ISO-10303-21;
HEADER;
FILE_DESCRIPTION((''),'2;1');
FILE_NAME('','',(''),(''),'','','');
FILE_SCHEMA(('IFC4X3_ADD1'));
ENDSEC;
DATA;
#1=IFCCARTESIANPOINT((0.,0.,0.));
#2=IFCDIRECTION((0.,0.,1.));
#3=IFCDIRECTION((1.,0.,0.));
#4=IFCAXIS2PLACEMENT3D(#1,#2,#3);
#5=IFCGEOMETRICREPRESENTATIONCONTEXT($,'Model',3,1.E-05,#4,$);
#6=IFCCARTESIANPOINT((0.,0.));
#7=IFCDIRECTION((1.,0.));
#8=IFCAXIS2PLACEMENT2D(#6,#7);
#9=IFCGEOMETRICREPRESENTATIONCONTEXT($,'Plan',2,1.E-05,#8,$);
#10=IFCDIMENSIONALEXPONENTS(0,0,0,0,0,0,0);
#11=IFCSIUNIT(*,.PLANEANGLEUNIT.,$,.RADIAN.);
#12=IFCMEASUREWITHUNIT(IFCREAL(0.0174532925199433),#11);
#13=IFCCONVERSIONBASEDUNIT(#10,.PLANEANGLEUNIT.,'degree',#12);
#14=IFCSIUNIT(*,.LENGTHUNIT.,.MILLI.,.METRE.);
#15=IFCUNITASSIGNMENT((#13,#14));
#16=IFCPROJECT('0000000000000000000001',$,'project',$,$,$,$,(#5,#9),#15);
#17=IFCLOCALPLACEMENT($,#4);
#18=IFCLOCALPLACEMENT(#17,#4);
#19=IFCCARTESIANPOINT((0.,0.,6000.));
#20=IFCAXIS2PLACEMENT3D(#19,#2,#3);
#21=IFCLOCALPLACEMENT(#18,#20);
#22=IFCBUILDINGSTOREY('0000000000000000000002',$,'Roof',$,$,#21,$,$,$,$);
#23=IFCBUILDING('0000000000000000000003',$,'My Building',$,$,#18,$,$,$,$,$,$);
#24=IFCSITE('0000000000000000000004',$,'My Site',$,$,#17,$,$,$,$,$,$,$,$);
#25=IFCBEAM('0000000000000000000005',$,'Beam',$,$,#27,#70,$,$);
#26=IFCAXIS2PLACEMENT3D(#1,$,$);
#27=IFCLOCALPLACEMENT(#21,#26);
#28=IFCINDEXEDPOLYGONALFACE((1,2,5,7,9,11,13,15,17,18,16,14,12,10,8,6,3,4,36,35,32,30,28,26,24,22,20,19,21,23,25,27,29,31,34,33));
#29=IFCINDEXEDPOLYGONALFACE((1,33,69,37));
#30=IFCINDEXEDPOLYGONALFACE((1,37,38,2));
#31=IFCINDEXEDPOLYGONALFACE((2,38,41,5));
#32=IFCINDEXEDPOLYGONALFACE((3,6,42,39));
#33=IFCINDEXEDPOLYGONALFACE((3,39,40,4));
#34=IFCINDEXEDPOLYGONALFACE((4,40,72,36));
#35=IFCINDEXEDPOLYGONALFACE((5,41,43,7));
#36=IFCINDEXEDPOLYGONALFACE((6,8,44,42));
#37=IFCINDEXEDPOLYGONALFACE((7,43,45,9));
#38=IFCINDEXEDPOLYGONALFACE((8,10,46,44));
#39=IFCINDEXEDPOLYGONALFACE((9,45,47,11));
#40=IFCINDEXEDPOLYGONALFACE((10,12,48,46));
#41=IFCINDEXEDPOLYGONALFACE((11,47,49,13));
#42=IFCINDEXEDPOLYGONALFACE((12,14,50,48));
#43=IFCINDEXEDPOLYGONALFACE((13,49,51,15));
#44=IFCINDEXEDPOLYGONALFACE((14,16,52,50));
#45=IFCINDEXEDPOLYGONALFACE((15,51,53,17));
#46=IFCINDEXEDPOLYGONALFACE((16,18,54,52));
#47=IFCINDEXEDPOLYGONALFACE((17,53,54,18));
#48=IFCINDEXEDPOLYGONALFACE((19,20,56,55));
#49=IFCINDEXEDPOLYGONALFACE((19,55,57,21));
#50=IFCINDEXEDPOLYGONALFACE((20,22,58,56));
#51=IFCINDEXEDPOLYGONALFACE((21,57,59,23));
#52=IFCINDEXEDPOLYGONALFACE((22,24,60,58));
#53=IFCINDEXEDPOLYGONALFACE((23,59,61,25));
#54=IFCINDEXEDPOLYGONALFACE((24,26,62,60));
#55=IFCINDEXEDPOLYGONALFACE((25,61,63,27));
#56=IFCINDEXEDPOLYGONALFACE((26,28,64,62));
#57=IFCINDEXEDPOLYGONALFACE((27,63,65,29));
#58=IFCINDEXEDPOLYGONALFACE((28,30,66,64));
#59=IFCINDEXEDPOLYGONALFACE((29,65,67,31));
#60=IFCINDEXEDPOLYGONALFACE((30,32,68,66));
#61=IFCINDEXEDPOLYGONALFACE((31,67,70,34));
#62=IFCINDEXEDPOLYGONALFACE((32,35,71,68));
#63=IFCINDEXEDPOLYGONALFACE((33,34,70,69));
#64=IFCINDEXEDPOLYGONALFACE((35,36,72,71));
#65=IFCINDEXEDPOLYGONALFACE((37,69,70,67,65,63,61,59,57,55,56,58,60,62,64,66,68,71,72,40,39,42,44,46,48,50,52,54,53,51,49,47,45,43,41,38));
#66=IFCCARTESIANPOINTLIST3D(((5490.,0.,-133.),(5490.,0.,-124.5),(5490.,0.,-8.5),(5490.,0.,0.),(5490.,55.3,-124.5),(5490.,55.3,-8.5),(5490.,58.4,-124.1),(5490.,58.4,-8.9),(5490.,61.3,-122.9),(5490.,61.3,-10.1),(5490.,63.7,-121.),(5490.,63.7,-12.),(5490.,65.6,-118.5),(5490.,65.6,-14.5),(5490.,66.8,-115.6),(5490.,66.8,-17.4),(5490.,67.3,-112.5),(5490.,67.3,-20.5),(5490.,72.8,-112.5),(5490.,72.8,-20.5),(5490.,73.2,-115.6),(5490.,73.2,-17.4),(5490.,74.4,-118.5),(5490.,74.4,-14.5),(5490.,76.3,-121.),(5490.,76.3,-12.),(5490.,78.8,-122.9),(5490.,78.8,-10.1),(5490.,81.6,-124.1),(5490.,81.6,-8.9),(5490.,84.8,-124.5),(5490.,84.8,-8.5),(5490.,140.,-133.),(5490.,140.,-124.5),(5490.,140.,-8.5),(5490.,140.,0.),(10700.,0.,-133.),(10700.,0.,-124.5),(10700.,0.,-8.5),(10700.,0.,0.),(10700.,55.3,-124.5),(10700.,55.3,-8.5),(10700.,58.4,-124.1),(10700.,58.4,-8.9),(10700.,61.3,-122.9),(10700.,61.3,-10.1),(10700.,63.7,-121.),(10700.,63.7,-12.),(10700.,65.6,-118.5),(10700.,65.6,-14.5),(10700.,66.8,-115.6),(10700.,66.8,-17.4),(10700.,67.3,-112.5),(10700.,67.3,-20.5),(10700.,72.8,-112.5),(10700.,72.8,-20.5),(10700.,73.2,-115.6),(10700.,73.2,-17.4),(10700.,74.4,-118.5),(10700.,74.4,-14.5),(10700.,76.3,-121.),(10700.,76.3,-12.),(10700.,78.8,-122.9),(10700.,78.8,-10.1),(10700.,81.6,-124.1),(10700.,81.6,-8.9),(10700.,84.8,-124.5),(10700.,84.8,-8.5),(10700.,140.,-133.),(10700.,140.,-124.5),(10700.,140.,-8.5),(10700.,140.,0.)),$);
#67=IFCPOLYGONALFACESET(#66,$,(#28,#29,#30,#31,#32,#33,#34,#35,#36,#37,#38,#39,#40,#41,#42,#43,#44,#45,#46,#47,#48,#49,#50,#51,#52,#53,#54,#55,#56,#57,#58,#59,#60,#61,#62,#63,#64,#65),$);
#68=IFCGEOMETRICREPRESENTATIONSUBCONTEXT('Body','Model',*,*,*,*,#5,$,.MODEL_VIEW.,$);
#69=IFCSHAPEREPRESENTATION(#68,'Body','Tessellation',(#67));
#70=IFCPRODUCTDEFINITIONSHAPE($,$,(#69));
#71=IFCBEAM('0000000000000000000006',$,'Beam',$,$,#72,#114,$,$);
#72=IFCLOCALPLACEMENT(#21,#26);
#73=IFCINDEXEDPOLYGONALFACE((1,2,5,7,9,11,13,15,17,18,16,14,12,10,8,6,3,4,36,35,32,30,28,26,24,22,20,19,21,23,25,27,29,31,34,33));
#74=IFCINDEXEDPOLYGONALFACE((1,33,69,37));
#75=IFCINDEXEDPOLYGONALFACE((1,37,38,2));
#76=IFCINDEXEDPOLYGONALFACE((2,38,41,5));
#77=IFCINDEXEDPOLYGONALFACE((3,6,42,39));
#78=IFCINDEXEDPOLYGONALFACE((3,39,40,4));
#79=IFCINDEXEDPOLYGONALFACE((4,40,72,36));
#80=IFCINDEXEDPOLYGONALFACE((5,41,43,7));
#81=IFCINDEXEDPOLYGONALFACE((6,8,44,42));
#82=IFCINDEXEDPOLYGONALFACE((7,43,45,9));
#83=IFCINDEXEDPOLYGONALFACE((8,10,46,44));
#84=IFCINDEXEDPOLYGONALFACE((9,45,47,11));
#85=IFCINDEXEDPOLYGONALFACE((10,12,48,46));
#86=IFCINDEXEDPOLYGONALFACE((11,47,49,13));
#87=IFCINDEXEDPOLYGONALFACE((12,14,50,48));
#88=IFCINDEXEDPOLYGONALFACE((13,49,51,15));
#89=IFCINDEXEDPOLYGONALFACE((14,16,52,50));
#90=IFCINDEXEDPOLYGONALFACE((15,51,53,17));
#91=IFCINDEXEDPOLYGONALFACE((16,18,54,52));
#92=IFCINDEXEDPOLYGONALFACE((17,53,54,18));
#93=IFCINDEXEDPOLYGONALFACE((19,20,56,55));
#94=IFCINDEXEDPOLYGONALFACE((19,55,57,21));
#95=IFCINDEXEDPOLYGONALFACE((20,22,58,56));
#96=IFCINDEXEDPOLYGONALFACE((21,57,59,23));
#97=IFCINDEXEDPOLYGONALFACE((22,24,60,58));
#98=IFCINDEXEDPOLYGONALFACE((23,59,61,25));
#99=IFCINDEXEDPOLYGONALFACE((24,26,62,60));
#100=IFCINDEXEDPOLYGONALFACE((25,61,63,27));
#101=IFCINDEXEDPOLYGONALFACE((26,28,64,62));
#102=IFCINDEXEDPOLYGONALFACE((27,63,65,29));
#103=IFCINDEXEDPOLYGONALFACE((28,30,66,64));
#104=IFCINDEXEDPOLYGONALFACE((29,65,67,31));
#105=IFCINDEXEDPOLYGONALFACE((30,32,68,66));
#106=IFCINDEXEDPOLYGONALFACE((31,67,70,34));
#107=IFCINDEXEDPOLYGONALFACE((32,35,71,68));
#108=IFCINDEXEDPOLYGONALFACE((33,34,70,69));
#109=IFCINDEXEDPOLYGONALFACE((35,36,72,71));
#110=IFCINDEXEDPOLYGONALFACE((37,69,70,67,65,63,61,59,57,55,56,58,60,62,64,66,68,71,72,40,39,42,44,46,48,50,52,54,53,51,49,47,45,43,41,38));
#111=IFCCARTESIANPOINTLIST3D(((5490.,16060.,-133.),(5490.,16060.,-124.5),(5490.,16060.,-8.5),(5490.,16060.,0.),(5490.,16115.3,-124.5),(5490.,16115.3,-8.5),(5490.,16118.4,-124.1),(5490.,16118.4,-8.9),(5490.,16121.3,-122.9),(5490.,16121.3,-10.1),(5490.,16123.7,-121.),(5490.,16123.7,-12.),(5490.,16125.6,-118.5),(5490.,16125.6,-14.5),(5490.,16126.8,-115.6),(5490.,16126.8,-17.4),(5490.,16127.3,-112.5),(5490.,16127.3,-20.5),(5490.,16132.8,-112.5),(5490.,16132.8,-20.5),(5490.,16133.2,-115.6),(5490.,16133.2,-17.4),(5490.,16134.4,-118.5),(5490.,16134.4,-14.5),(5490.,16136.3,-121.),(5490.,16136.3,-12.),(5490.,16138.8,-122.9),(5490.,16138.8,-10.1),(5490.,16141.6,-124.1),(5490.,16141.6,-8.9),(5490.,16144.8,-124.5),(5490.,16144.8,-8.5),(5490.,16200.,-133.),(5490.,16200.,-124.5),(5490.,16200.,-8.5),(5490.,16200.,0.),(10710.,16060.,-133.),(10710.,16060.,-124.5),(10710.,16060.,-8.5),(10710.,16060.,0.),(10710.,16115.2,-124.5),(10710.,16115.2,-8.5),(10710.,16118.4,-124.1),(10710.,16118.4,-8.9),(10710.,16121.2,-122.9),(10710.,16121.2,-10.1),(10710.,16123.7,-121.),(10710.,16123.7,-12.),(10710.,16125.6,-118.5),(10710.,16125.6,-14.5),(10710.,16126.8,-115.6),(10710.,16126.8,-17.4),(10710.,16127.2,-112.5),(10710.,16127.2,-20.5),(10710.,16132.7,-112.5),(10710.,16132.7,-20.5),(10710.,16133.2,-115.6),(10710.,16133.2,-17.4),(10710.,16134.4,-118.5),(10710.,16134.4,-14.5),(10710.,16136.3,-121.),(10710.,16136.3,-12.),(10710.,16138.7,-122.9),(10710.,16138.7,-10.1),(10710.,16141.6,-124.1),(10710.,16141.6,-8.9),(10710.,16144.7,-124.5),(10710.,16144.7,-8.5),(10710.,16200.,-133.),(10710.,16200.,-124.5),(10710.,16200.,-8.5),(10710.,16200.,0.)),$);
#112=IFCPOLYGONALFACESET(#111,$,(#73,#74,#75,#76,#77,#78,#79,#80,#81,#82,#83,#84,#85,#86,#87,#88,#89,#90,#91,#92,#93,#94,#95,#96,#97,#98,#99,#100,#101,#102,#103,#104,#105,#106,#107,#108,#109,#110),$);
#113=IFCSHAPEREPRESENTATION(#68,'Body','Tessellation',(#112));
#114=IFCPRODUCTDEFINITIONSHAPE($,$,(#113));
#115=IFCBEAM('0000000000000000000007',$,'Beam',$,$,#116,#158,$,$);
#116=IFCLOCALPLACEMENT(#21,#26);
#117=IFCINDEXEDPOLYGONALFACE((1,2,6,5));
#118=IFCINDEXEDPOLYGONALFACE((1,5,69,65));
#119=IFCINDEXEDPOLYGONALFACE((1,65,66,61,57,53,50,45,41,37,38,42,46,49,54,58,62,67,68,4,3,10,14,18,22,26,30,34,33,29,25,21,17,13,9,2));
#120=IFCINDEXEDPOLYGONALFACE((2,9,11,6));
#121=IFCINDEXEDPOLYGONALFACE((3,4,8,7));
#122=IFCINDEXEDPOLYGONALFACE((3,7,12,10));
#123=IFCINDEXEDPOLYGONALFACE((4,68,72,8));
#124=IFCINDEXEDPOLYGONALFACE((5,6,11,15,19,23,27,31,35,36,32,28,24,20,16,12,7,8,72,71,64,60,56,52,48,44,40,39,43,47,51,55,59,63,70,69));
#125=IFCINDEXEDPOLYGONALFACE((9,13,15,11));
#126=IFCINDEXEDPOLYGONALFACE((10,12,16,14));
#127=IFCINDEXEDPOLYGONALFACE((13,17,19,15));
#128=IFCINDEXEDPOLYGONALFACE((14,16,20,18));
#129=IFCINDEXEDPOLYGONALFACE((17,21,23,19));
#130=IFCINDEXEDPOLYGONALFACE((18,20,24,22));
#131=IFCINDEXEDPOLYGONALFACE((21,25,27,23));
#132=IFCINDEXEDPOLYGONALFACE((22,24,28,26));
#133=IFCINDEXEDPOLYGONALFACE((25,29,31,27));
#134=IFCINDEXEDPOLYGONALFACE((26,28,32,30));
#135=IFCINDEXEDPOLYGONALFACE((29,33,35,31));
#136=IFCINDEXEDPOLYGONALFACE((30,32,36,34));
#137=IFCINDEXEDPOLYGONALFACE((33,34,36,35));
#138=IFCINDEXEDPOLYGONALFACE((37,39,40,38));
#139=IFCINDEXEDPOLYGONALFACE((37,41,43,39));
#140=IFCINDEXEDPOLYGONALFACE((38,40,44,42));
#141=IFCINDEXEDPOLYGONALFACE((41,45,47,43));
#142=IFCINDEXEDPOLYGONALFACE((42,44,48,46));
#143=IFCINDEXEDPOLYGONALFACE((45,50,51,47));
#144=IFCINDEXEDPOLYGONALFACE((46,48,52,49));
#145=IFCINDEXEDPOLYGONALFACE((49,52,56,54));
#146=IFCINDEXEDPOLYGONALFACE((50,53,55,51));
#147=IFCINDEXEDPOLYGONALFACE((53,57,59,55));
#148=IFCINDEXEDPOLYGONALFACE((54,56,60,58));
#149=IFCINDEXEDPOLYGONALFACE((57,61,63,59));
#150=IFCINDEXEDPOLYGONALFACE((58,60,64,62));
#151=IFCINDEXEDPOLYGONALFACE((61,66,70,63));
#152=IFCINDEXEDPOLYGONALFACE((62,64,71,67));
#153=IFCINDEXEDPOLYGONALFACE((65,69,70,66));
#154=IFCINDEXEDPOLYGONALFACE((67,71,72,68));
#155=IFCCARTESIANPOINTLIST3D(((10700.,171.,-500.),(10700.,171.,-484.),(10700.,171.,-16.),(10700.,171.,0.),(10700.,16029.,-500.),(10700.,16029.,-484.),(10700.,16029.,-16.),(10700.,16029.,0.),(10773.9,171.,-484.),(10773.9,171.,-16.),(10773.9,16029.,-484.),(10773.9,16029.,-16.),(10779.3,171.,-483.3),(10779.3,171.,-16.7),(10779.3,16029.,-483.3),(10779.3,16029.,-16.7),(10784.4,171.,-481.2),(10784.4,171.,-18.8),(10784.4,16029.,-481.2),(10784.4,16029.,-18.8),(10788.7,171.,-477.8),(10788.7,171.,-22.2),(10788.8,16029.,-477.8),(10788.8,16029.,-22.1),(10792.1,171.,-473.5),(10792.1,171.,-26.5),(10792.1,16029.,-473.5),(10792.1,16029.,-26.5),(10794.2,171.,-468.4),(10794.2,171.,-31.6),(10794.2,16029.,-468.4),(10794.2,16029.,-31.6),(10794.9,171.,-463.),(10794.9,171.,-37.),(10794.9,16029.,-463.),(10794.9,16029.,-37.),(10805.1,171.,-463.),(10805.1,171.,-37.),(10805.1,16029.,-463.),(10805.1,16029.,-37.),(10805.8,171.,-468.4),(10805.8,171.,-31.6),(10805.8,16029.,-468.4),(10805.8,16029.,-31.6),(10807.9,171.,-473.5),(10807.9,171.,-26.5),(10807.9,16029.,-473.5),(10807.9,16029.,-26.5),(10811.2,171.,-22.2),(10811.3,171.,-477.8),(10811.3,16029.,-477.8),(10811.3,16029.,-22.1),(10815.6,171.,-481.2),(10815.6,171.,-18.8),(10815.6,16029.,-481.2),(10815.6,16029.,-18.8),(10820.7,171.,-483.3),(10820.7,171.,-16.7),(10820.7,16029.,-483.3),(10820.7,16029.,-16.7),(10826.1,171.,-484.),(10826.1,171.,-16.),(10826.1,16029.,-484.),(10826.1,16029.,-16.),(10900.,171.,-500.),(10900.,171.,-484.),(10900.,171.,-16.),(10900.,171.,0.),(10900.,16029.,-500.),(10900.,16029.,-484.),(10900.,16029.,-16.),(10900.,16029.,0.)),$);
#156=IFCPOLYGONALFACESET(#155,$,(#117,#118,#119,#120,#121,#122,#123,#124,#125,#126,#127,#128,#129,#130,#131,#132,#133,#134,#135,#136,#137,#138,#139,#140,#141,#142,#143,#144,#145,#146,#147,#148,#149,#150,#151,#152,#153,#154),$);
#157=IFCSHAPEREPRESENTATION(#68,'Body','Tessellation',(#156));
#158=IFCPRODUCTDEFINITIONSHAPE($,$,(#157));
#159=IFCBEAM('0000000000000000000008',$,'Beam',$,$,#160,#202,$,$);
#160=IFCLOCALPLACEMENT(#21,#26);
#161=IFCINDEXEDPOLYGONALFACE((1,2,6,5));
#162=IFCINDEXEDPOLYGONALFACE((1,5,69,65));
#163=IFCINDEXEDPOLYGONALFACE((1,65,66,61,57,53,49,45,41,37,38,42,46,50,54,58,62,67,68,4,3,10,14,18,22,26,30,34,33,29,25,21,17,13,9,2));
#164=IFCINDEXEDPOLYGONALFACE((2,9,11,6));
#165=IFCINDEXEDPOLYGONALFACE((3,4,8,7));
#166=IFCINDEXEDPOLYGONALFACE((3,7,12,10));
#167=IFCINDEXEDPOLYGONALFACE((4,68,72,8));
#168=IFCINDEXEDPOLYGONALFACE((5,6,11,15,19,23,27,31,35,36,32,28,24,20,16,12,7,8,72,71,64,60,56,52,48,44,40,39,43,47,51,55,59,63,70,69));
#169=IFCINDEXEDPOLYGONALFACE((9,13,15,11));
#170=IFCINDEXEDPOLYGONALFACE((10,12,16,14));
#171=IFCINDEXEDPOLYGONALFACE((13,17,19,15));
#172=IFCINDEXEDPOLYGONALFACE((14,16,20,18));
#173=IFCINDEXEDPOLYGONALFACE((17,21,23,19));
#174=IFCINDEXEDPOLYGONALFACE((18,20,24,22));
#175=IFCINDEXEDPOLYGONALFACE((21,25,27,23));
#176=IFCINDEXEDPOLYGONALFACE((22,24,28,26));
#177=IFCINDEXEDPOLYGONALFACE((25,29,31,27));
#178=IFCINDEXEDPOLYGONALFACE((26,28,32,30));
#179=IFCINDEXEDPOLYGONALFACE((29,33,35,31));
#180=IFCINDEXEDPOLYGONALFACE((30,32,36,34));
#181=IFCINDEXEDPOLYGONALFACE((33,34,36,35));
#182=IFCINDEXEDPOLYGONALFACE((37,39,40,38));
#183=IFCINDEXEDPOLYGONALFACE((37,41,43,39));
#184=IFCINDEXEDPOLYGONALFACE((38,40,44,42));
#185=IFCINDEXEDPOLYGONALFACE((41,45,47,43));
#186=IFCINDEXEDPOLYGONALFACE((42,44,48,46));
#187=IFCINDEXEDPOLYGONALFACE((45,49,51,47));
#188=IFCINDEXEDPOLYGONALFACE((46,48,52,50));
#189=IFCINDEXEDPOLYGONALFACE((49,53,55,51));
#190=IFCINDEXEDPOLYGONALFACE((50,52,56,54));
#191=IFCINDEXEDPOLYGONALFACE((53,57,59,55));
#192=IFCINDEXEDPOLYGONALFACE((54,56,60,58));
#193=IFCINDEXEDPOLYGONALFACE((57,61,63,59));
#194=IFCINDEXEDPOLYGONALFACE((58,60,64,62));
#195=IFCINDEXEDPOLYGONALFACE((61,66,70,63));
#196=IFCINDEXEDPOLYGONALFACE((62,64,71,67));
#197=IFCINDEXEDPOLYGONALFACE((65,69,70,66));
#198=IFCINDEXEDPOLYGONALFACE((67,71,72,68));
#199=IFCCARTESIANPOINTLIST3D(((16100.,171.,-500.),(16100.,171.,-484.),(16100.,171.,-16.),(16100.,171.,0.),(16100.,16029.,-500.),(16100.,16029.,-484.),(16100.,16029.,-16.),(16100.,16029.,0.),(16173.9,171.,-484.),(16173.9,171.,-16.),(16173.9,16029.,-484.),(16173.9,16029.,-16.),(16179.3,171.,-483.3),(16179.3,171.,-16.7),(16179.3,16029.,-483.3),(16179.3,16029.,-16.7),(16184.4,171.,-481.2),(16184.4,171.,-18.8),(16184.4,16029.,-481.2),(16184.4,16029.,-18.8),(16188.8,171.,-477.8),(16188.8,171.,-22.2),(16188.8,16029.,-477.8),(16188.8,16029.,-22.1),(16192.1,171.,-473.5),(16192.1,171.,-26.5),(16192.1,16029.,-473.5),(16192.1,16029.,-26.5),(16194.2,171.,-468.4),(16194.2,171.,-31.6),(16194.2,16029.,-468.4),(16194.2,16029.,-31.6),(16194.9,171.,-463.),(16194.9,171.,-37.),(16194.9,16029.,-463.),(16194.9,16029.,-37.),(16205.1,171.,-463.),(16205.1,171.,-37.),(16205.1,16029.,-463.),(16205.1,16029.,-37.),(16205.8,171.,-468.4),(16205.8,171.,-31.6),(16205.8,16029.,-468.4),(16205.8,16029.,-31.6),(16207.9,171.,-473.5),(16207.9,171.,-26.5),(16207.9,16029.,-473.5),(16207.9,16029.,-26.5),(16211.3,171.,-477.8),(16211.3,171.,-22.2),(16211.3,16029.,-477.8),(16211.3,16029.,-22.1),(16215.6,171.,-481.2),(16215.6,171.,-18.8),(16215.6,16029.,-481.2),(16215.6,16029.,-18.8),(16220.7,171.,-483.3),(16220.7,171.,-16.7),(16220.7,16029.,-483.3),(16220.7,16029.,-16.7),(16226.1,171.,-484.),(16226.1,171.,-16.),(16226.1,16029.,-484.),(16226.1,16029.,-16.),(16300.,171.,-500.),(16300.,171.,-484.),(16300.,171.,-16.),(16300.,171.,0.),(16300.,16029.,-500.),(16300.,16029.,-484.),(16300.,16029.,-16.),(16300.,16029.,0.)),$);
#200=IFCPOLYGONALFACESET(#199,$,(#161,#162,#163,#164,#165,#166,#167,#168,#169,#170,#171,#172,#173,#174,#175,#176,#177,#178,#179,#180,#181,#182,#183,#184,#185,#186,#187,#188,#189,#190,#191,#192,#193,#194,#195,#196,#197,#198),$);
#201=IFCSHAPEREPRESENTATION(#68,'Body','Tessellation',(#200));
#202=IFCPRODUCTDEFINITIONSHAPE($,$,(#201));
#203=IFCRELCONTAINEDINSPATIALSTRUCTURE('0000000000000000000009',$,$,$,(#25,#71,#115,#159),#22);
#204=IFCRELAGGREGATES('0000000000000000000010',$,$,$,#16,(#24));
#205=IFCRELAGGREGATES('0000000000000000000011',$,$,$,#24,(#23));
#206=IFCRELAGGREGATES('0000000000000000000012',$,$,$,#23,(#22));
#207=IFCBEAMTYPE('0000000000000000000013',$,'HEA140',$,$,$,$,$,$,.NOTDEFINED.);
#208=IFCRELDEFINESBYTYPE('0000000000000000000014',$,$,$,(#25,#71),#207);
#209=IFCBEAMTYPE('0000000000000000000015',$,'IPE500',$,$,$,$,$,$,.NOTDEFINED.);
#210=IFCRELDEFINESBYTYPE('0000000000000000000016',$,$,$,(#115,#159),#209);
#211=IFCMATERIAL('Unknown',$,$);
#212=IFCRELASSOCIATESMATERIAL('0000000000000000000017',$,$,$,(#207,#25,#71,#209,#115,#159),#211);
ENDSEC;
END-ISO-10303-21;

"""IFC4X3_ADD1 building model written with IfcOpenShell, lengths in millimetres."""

from ifc_helpers import new_model, entity, si_unit, converted_unit, frame, origin_with_axes, origin_2d_with_axis, place, context, subcontext, project, spatial, i_section, extrude, material, material_profile, profile_set, profile_usage, type_object, element, save


model = new_model("IFC4X3_ADD1")

# Units and contexts
model_context = context("Model", 3, precision=1e-05, world=origin_with_axes())
plan_context = context("Plan", 2, precision=1e-05, world=origin_2d_with_axis())
body_context = subcontext(model_context, "Body", "Model", "MODEL_VIEW")
ifc_project = project(units=[converted_unit("PLANEANGLEUNIT", "degree", entity("IfcReal", 0.0174532925199433), si_unit("PLANEANGLEUNIT", "RADIAN"), dimensions=[0, 0, 0, 0, 0, 0, 0]), si_unit("LENGTHUNIT", "METRE", prefix="MILLI")], contexts=[model_context, plan_context])

# Site, building, storey
site_placement = place(None, origin_with_axes())
site = spatial("IfcSite", under=ifc_project, at=site_placement, Name="My Site")
building_placement = place(site_placement, origin_with_axes())
building = spatial("IfcBuilding", under=site, at=building_placement, Name="My Building")
storey_placement = place(building_placement, frame((0.0, 0.0, 6000.0), z_axis=(0.0, 0.0, 1.0), x_axis=(1.0, 0.0, 0.0)))
storey = spatial("IfcBuildingStorey", under=building, at=storey_placement, Name="Roof")

# Beams
ifc_material = material(Name="Unknown")
ifc_material_profile_1 = material_profile(ifc_material, i_section(OverallWidth=140.0, OverallDepth=133.0, WebThickness=5.5, FlangeThickness=8.5, FilletRadius=12.0))
ifc_profile_set_1 = profile_set([ifc_material_profile_1])
beam_type_1 = type_object("IfcBeamType", Name="HEA140", PredefinedType="NOTDEFINED", material=ifc_profile_set_1)
ifc_profile_usage_1 = profile_usage(ifc_profile_set_1, cardinal=7)
beam_1_placement = place(storey_placement, frame((10700.0, 0.0, 0.0), z_axis=(-1.0, 0.0, 0.0), x_axis=(0.0, -1.0, 0.0)))
element("IfcBeam", 1, at=beam_1_placement, inside=storey, type_object=beam_type_1, material=ifc_profile_usage_1, Name="Beam", context=body_context, shape_type="SweptSolid", body=[
    extrude(i_section(OverallWidth=140.0, OverallDepth=133.0, WebThickness=5.5, FlangeThickness=8.5, FilletRadius=12.0), frame((-70.0, -66.5, 0.0), z_axis=(0.0, 0.0, 1.0), x_axis=(1.0, 0.0, 0.0)), (0.0, 0.0, 1.0), 5210.0),
])
ifc_profile_usage_2 = profile_usage(ifc_profile_set_1, cardinal=7)
beam_2_placement = place(storey_placement, frame((5490.0, 16200.0, 0.0), z_axis=(1.0, 0.0, 0.0), x_axis=(0.0, 1.0, 0.0)))
element("IfcBeam", 2, at=beam_2_placement, inside=storey, type_object=beam_type_1, material=ifc_profile_usage_2, Name="Beam", context=body_context, shape_type="SweptSolid", body=[
    extrude(i_section(OverallWidth=140.0, OverallDepth=133.0, WebThickness=5.5, FlangeThickness=8.5, FilletRadius=12.0), frame((-70.0, -66.5, 0.0), z_axis=(0.0, 0.0, 1.0), x_axis=(1.0, 0.0, 0.0)), (0.0, 0.0, 1.0), 5220.0),
])
ifc_material_profile_2 = material_profile(ifc_material, i_section(OverallWidth=200.0, OverallDepth=500.0, WebThickness=10.2, FlangeThickness=16.0, FilletRadius=21.0))
ifc_profile_set_2 = profile_set([ifc_material_profile_2])
ifc_profile_usage_3 = profile_usage(ifc_profile_set_2, cardinal=8)
beam_type_2 = type_object("IfcBeamType", Name="IPE500", PredefinedType="NOTDEFINED", material=ifc_profile_set_2)
beam_3_placement = place(storey_placement, frame((10800.0, 171.0, 0.0), z_axis=(0.0, 1.0, 0.0), x_axis=(-1.0, 0.0, 0.0)))
element("IfcBeam", 3, at=beam_3_placement, inside=storey, type_object=beam_type_2, material=ifc_profile_usage_3, Name="Beam", context=body_context, shape_type="SweptSolid", body=[
    extrude(i_section(OverallWidth=200.0, OverallDepth=500.0, WebThickness=10.2, FlangeThickness=16.0, FilletRadius=21.0), frame((0.0, -250.0, 0.0), z_axis=(0.0, 0.0, 1.0), x_axis=(1.0, 0.0, 0.0)), (0.0, 0.0, 1.0), 15858.0),
])
ifc_profile_usage_4 = profile_usage(ifc_profile_set_2, cardinal=8)
beam_4_placement = place(storey_placement, frame((16200.0, 171.0, 0.0), z_axis=(0.0, 1.0, 0.0), x_axis=(-1.0, 0.0, 0.0)))
element("IfcBeam", 4, at=beam_4_placement, inside=storey, type_object=beam_type_2, material=ifc_profile_usage_4, Name="Beam", context=body_context, shape_type="SweptSolid", body=[
    extrude(i_section(OverallWidth=200.0, OverallDepth=500.0, WebThickness=10.2, FlangeThickness=16.0, FilletRadius=21.0), frame((0.0, -250.0, 0.0), z_axis=(0.0, 0.0, 1.0), x_axis=(1.0, 0.0, 0.0)), (0.0, 0.0, 1.0), 15858.0),
])

save(model, "model.ifc")
